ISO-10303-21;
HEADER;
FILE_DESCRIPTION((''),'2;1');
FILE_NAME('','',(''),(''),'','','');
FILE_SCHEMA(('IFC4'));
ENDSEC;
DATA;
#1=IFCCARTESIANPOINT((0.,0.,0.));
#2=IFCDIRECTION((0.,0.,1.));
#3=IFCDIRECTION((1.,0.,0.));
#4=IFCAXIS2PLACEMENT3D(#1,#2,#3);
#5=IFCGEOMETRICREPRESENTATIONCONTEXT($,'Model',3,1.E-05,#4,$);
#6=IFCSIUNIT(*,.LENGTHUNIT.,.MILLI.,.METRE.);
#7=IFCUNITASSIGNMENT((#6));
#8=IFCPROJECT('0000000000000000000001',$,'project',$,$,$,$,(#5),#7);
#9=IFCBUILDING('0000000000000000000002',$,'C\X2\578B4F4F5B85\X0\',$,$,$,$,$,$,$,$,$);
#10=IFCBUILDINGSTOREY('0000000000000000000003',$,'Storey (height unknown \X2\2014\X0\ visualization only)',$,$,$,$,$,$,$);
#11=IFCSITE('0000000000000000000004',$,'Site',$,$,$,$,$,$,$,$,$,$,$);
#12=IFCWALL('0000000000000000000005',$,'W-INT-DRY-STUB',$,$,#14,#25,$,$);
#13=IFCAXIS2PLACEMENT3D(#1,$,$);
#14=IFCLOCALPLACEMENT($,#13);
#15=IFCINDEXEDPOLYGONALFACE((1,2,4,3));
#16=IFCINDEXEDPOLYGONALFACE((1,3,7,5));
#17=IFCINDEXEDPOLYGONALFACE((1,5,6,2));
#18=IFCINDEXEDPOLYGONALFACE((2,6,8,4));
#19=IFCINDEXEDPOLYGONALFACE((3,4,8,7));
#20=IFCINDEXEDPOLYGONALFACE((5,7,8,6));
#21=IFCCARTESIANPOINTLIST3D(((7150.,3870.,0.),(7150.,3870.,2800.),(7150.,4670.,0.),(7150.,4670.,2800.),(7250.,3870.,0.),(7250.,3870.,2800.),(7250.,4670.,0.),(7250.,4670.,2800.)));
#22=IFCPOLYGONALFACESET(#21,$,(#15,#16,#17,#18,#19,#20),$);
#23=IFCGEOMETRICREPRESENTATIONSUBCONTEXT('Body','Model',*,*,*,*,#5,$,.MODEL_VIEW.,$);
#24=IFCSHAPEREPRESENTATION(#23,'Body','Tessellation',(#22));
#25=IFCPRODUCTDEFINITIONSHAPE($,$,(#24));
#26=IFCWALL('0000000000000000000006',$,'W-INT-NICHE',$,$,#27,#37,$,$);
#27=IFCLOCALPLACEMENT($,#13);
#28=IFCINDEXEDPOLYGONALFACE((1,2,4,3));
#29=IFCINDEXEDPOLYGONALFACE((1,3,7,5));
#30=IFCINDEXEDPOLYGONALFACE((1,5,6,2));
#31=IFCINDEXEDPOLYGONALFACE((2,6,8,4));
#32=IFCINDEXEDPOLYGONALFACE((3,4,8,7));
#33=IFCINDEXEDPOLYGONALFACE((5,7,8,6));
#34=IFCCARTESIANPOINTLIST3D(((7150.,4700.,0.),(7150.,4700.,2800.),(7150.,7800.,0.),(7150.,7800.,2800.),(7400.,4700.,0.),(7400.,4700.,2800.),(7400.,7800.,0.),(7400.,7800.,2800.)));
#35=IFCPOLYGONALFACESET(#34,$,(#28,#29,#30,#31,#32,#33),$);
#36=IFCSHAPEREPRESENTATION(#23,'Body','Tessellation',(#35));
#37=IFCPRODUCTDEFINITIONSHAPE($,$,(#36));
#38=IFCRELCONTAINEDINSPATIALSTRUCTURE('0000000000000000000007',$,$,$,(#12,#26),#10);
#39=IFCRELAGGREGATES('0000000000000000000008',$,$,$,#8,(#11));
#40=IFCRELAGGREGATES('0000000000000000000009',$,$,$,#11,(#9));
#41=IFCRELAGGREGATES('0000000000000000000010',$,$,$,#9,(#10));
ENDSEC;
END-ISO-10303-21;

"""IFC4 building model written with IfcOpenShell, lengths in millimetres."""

from ifc_helpers import new_model, si_unit, frame, frame_2d, origin_with_axes, place, context, subcontext, project, spatial, rectangle, extrude, element, save


model = new_model("IFC4")

# Units and contexts
model_context = context("Model", 3, precision=1e-05, world=origin_with_axes())
body_context = subcontext(model_context, "Body", "Model", "MODEL_VIEW")
ifc_project = project(units=[si_unit("LENGTHUNIT", "METRE", prefix="MILLI")], contexts=[model_context])

# Site, building, storey
site = spatial("IfcSite", under=ifc_project, Name="Site")
building = spatial("IfcBuilding", under=site, Name="C型住宅")
storey = spatial("IfcBuildingStorey", under=building, Name="Storey (height unknown — visualization only)")

# Walls
wall_1_placement = place(None, frame((7150.0, 3870.0, 0.0), z_axis=(0.0, 0.0, 1.0), x_axis=(1.0, 0.0, 0.0)))
element("IfcWall", 1, at=wall_1_placement, inside=storey, Name="W-INT-DRY-STUB", context=body_context, shape_type="SweptSolid", body=[
    extrude(rectangle(XDim=100.0, YDim=800.0, at=frame_2d((50.0, 400.0))), origin_with_axes(), (0.0, 0.0, 1.0), 2800.0),
])
wall_2_placement = place(None, frame((7150.0, 4700.0, 0.0), z_axis=(0.0, 0.0, 1.0), x_axis=(1.0, 0.0, 0.0)))
element("IfcWall", 2, at=wall_2_placement, inside=storey, Name="W-INT-NICHE", context=body_context, shape_type="SweptSolid", body=[
    extrude(rectangle(XDim=250.0, YDim=3100.0, at=frame_2d((125.0, 1550.0))), origin_with_axes(), (0.0, 0.0, 1.0), 2800.0),
])

save(model, "model.ifc")
